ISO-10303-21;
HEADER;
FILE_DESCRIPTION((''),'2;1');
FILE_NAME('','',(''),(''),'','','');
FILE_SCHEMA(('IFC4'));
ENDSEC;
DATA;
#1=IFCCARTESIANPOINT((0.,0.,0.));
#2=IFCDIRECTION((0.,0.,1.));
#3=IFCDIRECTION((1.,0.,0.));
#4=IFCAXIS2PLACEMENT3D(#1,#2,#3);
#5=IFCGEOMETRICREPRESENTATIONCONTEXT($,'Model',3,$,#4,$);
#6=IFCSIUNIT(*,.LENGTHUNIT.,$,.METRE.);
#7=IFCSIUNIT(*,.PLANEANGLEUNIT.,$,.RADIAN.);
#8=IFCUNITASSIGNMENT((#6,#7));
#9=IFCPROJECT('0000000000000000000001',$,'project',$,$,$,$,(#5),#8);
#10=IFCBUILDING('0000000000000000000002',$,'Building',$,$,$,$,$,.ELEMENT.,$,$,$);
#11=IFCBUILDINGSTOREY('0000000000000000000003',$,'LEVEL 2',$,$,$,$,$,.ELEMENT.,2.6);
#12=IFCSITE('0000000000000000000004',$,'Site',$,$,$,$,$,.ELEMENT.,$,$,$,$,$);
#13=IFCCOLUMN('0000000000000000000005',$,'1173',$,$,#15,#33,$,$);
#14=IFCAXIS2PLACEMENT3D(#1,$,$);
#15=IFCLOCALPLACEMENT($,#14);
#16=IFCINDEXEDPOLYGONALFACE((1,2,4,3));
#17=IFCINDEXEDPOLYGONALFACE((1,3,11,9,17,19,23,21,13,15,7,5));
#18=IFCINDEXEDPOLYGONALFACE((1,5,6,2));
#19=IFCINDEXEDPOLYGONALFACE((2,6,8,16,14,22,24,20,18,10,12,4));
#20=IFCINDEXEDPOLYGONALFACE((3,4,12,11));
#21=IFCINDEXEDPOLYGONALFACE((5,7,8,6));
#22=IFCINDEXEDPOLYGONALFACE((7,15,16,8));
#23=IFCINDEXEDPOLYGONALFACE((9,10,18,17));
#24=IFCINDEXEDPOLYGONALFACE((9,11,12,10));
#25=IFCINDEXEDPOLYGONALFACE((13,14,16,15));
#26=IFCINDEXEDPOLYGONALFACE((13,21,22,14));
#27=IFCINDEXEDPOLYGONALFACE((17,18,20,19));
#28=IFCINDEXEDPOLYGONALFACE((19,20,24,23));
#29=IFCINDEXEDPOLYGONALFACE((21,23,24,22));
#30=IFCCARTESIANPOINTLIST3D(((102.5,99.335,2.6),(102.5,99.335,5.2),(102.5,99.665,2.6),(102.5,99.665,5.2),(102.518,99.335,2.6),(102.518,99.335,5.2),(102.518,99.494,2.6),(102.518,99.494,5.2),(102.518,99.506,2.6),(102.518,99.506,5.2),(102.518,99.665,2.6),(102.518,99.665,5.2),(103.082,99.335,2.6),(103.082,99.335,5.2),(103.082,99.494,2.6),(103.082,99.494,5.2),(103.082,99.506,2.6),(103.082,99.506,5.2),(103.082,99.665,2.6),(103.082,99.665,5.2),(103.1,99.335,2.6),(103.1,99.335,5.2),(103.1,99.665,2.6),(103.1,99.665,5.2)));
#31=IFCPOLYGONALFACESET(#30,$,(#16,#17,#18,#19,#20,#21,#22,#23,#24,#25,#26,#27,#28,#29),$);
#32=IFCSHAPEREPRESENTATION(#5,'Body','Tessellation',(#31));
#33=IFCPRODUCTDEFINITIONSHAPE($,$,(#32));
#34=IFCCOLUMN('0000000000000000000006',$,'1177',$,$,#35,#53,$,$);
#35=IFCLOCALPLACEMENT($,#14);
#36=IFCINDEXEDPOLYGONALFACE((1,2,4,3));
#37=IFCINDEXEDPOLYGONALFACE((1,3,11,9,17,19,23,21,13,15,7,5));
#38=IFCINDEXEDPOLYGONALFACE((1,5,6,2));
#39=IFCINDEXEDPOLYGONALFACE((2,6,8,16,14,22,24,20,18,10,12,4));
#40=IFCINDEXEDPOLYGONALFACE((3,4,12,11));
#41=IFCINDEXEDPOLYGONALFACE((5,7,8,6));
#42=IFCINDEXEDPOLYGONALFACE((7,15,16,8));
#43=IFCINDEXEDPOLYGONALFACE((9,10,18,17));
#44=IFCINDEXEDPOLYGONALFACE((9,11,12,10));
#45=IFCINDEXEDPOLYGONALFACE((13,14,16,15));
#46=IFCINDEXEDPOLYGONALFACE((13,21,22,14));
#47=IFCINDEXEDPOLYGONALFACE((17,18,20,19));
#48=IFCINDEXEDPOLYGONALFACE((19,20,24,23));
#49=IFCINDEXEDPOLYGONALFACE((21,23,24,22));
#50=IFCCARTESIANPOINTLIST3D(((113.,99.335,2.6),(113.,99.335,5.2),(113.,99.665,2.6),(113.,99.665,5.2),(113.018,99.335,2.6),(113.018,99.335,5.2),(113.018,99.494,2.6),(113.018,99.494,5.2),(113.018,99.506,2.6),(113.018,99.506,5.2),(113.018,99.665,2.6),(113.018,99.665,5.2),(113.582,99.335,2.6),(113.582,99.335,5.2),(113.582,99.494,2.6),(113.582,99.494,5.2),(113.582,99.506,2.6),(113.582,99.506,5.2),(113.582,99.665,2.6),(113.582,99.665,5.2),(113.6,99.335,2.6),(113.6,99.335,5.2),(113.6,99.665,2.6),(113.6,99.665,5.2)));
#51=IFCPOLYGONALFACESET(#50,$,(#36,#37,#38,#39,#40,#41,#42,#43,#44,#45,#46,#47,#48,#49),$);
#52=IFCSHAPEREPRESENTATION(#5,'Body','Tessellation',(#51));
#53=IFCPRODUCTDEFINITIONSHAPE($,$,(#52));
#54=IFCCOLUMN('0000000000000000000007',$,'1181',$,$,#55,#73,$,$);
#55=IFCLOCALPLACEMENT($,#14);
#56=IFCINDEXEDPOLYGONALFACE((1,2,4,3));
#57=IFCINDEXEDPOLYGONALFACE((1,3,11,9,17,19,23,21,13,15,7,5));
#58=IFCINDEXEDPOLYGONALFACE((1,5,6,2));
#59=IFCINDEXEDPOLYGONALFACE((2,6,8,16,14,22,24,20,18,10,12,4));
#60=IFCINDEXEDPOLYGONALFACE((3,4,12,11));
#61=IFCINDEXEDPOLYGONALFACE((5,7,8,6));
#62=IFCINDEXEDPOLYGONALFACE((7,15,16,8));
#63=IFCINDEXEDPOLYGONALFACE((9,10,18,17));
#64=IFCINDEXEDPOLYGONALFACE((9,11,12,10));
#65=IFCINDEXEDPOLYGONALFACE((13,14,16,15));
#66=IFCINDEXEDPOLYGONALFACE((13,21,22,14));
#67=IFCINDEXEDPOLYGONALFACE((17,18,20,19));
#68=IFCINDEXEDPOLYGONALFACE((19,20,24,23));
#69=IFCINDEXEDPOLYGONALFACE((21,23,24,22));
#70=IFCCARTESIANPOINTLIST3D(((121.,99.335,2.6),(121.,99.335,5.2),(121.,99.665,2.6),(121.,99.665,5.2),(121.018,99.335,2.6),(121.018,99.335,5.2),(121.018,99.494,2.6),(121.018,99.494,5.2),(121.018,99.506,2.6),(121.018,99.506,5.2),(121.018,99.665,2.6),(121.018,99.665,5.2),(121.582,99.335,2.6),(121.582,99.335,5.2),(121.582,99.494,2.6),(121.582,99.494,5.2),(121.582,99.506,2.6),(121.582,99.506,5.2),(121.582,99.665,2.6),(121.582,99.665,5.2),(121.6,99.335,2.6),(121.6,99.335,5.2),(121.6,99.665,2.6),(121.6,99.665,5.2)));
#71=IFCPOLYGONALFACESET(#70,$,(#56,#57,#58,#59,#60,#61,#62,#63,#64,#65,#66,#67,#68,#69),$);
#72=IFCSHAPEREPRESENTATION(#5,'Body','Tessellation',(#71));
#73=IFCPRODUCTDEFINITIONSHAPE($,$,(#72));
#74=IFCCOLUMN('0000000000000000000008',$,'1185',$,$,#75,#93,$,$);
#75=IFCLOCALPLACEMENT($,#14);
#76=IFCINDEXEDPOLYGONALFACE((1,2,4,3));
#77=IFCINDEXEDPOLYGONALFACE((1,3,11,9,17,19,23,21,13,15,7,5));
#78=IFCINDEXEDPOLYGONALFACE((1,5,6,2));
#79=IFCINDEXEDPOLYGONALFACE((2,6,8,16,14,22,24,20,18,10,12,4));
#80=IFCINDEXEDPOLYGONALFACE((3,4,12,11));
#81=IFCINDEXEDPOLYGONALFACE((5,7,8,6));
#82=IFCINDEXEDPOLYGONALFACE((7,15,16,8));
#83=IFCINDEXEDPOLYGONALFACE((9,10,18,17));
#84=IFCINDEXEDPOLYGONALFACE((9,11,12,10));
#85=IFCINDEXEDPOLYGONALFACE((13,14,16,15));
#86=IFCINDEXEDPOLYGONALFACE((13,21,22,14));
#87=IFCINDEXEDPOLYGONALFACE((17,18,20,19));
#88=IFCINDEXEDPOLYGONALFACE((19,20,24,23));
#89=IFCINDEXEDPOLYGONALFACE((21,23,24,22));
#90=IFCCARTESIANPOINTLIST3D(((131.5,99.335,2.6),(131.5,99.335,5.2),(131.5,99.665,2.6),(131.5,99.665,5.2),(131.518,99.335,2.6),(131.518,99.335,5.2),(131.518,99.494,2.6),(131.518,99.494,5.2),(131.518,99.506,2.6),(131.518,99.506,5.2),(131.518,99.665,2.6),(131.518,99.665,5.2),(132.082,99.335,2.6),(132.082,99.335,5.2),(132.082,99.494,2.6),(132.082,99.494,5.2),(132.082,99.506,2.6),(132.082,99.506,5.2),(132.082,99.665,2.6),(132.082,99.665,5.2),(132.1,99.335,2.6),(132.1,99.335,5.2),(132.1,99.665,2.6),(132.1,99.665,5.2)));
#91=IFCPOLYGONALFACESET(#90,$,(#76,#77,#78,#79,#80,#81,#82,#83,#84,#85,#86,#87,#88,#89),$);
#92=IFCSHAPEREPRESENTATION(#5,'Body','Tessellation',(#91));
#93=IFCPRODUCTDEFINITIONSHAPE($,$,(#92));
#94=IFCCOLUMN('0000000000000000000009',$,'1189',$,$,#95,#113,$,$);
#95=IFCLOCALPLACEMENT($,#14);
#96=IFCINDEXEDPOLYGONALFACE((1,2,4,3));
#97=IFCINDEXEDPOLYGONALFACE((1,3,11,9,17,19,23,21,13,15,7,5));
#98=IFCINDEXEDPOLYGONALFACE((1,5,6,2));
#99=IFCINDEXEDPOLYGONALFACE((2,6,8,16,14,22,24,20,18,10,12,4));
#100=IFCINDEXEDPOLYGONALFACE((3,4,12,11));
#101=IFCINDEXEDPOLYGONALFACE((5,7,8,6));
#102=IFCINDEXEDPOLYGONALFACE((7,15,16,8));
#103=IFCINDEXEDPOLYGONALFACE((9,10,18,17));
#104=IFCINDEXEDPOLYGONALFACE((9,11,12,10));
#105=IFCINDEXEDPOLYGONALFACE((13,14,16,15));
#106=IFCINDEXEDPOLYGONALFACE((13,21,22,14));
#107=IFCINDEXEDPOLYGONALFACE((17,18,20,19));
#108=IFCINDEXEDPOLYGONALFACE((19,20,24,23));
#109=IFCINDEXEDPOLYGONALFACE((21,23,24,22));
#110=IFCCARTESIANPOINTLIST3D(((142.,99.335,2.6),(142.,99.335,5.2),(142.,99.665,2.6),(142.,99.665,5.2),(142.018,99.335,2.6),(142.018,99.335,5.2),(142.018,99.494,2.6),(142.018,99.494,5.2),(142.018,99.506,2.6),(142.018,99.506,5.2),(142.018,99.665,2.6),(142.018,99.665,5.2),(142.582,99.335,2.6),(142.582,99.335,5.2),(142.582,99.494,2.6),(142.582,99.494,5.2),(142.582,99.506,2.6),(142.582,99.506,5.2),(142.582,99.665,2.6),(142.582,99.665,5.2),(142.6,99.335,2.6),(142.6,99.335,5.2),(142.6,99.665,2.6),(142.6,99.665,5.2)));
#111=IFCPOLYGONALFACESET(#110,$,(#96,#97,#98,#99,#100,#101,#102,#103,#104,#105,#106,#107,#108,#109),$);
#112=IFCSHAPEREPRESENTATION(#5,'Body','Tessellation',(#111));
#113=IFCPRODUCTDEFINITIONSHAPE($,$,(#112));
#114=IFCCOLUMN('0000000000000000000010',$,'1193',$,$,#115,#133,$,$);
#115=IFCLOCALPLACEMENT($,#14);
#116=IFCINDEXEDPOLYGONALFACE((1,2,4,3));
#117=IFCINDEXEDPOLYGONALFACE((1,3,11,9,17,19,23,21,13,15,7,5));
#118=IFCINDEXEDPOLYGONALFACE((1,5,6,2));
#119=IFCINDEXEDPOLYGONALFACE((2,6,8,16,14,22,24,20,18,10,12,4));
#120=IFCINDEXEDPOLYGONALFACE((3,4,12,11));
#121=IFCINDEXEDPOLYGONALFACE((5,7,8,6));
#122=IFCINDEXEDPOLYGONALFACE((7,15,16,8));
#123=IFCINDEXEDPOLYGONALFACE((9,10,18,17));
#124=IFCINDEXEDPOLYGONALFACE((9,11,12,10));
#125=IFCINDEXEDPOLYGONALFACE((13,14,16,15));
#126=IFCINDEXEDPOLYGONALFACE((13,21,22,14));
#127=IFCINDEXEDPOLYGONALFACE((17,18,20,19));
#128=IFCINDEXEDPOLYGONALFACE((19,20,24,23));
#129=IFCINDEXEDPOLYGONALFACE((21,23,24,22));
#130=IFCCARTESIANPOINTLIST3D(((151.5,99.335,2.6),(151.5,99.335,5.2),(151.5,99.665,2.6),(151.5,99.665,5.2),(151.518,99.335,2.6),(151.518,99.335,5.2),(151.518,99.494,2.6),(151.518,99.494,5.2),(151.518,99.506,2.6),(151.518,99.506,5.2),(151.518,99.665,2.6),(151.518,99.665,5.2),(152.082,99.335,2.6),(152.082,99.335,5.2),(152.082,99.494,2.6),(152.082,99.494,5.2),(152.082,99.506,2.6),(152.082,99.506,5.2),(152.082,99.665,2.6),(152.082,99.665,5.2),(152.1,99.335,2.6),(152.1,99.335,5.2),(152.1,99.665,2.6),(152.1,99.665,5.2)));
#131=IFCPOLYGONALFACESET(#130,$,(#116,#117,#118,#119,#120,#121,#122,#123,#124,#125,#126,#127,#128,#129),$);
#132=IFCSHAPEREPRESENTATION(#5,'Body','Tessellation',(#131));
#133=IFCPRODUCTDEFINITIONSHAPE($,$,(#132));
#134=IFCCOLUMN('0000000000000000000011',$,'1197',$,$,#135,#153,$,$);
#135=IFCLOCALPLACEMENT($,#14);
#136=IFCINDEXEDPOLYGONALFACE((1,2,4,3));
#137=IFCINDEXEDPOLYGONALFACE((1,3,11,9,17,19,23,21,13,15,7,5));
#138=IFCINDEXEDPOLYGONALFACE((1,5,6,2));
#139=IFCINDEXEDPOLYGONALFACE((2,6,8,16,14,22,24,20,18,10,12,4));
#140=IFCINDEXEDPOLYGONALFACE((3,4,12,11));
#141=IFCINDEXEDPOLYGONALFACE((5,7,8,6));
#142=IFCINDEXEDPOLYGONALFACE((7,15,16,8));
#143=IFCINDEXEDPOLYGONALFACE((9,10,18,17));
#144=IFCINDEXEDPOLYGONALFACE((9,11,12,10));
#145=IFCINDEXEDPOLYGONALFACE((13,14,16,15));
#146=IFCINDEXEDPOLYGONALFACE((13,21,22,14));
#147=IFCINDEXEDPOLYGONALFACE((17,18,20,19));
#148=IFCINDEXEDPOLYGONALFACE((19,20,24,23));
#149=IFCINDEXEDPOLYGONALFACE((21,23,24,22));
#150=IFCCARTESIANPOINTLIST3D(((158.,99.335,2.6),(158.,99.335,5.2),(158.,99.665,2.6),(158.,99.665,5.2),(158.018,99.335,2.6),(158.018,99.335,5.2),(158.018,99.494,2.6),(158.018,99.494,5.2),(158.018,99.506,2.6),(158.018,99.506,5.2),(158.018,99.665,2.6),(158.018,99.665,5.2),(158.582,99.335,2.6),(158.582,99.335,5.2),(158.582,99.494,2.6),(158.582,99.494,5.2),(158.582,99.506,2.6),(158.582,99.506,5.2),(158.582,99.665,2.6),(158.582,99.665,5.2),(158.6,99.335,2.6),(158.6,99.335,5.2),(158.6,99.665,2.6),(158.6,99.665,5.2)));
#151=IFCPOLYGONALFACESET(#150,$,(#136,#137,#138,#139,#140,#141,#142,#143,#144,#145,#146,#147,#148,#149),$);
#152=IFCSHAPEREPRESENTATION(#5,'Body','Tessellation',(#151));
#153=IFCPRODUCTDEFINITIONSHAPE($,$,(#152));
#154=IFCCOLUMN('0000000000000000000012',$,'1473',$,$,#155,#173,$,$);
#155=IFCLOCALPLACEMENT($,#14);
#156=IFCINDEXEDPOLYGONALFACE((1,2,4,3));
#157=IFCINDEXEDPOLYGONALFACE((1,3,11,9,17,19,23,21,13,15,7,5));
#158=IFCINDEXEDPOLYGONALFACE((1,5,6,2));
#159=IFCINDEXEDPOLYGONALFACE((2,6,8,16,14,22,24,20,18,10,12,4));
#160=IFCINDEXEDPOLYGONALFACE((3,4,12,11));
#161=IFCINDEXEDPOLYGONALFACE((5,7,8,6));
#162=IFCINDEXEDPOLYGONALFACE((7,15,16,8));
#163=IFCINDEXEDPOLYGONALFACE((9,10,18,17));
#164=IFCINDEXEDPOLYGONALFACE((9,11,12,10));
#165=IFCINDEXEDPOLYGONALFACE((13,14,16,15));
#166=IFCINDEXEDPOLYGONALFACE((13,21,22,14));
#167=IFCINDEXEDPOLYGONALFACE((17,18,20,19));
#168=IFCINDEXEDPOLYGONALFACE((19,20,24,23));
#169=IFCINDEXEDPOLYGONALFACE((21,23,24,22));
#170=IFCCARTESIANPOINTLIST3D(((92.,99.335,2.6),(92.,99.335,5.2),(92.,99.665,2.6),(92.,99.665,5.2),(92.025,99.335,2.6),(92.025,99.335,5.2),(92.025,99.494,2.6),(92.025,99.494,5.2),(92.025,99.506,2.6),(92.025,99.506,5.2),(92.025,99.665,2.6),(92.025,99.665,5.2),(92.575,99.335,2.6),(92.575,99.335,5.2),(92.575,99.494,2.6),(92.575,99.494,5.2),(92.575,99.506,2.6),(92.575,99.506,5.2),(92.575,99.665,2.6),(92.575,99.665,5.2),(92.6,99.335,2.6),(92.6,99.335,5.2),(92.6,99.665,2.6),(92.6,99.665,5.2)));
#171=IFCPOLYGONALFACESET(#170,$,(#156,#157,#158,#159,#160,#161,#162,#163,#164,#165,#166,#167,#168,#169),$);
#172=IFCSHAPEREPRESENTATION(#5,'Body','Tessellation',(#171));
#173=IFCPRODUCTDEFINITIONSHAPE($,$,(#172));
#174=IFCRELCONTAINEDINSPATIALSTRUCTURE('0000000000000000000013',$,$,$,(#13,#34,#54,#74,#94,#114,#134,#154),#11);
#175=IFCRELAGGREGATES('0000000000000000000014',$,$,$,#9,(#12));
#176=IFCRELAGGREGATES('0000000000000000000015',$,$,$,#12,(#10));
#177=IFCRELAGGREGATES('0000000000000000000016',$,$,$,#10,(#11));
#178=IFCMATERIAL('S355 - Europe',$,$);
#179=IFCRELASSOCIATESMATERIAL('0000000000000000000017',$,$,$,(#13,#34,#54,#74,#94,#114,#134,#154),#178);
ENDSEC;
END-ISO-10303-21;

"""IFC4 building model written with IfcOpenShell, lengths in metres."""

from ifc_helpers import new_model, si_unit, frame, origin_with_axes, origin_2d_with_axis, place, context, project, spatial, i_section, extrude, material, material_profile, profile_set, profile_usage, element, save


model = new_model("IFC4")

# Units and contexts
model_context = context("Model", 3, world=origin_with_axes())
ifc_project = project(units=[si_unit("LENGTHUNIT", "METRE"), si_unit("PLANEANGLEUNIT", "RADIAN")], contexts=[model_context])

# Site, building, storey
site = spatial("IfcSite", under=ifc_project, Name="Site", CompositionType="ELEMENT")
building = spatial("IfcBuilding", under=site, Name="Building", CompositionType="ELEMENT")
storey = spatial("IfcBuildingStorey", under=building, Name="LEVEL 2", CompositionType="ELEMENT", Elevation=2.6)

# Columns
ifc_material = material(Name="S355 - Europe")
ifc_material_profile_1 = material_profile(ifc_material, i_section(OverallWidth=0.33, OverallDepth=0.6, WebThickness=0.012, FlangeThickness=0.018, at=origin_2d_with_axis()))
ifc_profile_set_1 = profile_set([ifc_material_profile_1])
ifc_profile_usage_1 = profile_usage(ifc_profile_set_1, cardinal=10)
column_1_placement = place(None, frame((102.8, 99.5, 2.6), z_axis=(0.0, 0.0, 1.0), x_axis=(0.0, -1.0, 0.0)))
element("IfcColumn", 1, at=column_1_placement, inside=storey, material=ifc_profile_usage_1, Name="1173", context=model_context, shape_type="SweptSolid", body=[
    extrude(i_section(OverallWidth=0.33, OverallDepth=0.6, WebThickness=0.012, FlangeThickness=0.018, at=origin_2d_with_axis()), origin_with_axes(), (0.0, 0.0, 1.0), 2.6),
])
ifc_material_profile_2 = material_profile(ifc_material, i_section(OverallWidth=0.33, OverallDepth=0.6, WebThickness=0.012, FlangeThickness=0.018, at=origin_2d_with_axis()))
ifc_profile_set_2 = profile_set([ifc_material_profile_2])
ifc_profile_usage_2 = profile_usage(ifc_profile_set_2, cardinal=10)
column_2_placement = place(None, frame((113.3, 99.5, 2.6), z_axis=(0.0, 0.0, 1.0), x_axis=(0.0, -1.0, 0.0)))
element("IfcColumn", 2, at=column_2_placement, inside=storey, material=ifc_profile_usage_2, Name="1177", context=model_context, shape_type="SweptSolid", body=[
    extrude(i_section(OverallWidth=0.33, OverallDepth=0.6, WebThickness=0.012, FlangeThickness=0.018, at=origin_2d_with_axis()), origin_with_axes(), (0.0, 0.0, 1.0), 2.6),
])
ifc_material_profile_3 = material_profile(ifc_material, i_section(OverallWidth=0.33, OverallDepth=0.6, WebThickness=0.012, FlangeThickness=0.018, at=origin_2d_with_axis()))
ifc_profile_set_3 = profile_set([ifc_material_profile_3])
ifc_profile_usage_3 = profile_usage(ifc_profile_set_3, cardinal=10)
column_3_placement = place(None, frame((121.3, 99.5, 2.6), z_axis=(0.0, 0.0, 1.0), x_axis=(0.0, -1.0, 0.0)))
element("IfcColumn", 3, at=column_3_placement, inside=storey, material=ifc_profile_usage_3, Name="1181", context=model_context, shape_type="SweptSolid", body=[
    extrude(i_section(OverallWidth=0.33, OverallDepth=0.6, WebThickness=0.012, FlangeThickness=0.018, at=origin_2d_with_axis()), origin_with_axes(), (0.0, 0.0, 1.0), 2.6),
])
ifc_material_profile_4 = material_profile(ifc_material, i_section(OverallWidth=0.33, OverallDepth=0.6, WebThickness=0.012, FlangeThickness=0.018, at=origin_2d_with_axis()))
ifc_profile_set_4 = profile_set([ifc_material_profile_4])
ifc_profile_usage_4 = profile_usage(ifc_profile_set_4, cardinal=10)
column_4_placement = place(None, frame((131.8, 99.5, 2.6), z_axis=(0.0, 0.0, 1.0), x_axis=(0.0, -1.0, 0.0)))
element("IfcColumn", 4, at=column_4_placement, inside=storey, material=ifc_profile_usage_4, Name="1185", context=model_context, shape_type="SweptSolid", body=[
    extrude(i_section(OverallWidth=0.33, OverallDepth=0.6, WebThickness=0.012, FlangeThickness=0.018, at=origin_2d_with_axis()), origin_with_axes(), (0.0, 0.0, 1.0), 2.6),
])
ifc_material_profile_5 = material_profile(ifc_material, i_section(OverallWidth=0.33, OverallDepth=0.6, WebThickness=0.012, FlangeThickness=0.018, at=origin_2d_with_axis()))
ifc_profile_set_5 = profile_set([ifc_material_profile_5])
ifc_profile_usage_5 = profile_usage(ifc_profile_set_5, cardinal=10)
column_5_placement = place(None, frame((142.3, 99.5, 2.6), z_axis=(0.0, 0.0, 1.0), x_axis=(0.0, -1.0, 0.0)))
element("IfcColumn", 5, at=column_5_placement, inside=storey, material=ifc_profile_usage_5, Name="1189", context=model_context, shape_type="SweptSolid", body=[
    extrude(i_section(OverallWidth=0.33, OverallDepth=0.6, WebThickness=0.012, FlangeThickness=0.018, at=origin_2d_with_axis()), origin_with_axes(), (0.0, 0.0, 1.0), 2.6),
])
ifc_material_profile_6 = material_profile(ifc_material, i_section(OverallWidth=0.33, OverallDepth=0.6, WebThickness=0.012, FlangeThickness=0.018, at=origin_2d_with_axis()))
ifc_profile_set_6 = profile_set([ifc_material_profile_6])
ifc_profile_usage_6 = profile_usage(ifc_profile_set_6, cardinal=10)
column_6_placement = place(None, frame((151.8, 99.5, 2.6), z_axis=(0.0, 0.0, 1.0), x_axis=(0.0, -1.0, 0.0)))
element("IfcColumn", 6, at=column_6_placement, inside=storey, material=ifc_profile_usage_6, Name="1193", context=model_context, shape_type="SweptSolid", body=[
    extrude(i_section(OverallWidth=0.33, OverallDepth=0.6, WebThickness=0.012, FlangeThickness=0.018, at=origin_2d_with_axis()), origin_with_axes(), (0.0, 0.0, 1.0), 2.6),
])
ifc_material_profile_7 = material_profile(ifc_material, i_section(OverallWidth=0.33, OverallDepth=0.6, WebThickness=0.012, FlangeThickness=0.018, at=origin_2d_with_axis()))
ifc_profile_set_7 = profile_set([ifc_material_profile_7])
ifc_profile_usage_7 = profile_usage(ifc_profile_set_7, cardinal=10)
column_7_placement = place(None, frame((158.3, 99.5, 2.6), z_axis=(0.0, 0.0, 1.0), x_axis=(0.0, -1.0, 0.0)))
element("IfcColumn", 7, at=column_7_placement, inside=storey, material=ifc_profile_usage_7, Name="1197", context=model_context, shape_type="SweptSolid", body=[
    extrude(i_section(OverallWidth=0.33, OverallDepth=0.6, WebThickness=0.012, FlangeThickness=0.018, at=origin_2d_with_axis()), origin_with_axes(), (0.0, 0.0, 1.0), 2.6),
])
ifc_material_profile_8 = material_profile(ifc_material, i_section(OverallWidth=0.33, OverallDepth=0.6, WebThickness=0.012, FlangeThickness=0.025, at=origin_2d_with_axis()))
ifc_profile_set_8 = profile_set([ifc_material_profile_8])
ifc_profile_usage_8 = profile_usage(ifc_profile_set_8, cardinal=10)
column_8_placement = place(None, frame((92.3, 99.5, 2.6), z_axis=(0.0, 0.0, 1.0), x_axis=(0.0, -1.0, 0.0)))
element("IfcColumn", 8, at=column_8_placement, inside=storey, material=ifc_profile_usage_8, Name="1473", context=model_context, shape_type="SweptSolid", body=[
    extrude(i_section(OverallWidth=0.33, OverallDepth=0.6, WebThickness=0.012, FlangeThickness=0.025, at=origin_2d_with_axis()), origin_with_axes(), (0.0, 0.0, 1.0), 2.6),
])

save(model, "model.ifc")
